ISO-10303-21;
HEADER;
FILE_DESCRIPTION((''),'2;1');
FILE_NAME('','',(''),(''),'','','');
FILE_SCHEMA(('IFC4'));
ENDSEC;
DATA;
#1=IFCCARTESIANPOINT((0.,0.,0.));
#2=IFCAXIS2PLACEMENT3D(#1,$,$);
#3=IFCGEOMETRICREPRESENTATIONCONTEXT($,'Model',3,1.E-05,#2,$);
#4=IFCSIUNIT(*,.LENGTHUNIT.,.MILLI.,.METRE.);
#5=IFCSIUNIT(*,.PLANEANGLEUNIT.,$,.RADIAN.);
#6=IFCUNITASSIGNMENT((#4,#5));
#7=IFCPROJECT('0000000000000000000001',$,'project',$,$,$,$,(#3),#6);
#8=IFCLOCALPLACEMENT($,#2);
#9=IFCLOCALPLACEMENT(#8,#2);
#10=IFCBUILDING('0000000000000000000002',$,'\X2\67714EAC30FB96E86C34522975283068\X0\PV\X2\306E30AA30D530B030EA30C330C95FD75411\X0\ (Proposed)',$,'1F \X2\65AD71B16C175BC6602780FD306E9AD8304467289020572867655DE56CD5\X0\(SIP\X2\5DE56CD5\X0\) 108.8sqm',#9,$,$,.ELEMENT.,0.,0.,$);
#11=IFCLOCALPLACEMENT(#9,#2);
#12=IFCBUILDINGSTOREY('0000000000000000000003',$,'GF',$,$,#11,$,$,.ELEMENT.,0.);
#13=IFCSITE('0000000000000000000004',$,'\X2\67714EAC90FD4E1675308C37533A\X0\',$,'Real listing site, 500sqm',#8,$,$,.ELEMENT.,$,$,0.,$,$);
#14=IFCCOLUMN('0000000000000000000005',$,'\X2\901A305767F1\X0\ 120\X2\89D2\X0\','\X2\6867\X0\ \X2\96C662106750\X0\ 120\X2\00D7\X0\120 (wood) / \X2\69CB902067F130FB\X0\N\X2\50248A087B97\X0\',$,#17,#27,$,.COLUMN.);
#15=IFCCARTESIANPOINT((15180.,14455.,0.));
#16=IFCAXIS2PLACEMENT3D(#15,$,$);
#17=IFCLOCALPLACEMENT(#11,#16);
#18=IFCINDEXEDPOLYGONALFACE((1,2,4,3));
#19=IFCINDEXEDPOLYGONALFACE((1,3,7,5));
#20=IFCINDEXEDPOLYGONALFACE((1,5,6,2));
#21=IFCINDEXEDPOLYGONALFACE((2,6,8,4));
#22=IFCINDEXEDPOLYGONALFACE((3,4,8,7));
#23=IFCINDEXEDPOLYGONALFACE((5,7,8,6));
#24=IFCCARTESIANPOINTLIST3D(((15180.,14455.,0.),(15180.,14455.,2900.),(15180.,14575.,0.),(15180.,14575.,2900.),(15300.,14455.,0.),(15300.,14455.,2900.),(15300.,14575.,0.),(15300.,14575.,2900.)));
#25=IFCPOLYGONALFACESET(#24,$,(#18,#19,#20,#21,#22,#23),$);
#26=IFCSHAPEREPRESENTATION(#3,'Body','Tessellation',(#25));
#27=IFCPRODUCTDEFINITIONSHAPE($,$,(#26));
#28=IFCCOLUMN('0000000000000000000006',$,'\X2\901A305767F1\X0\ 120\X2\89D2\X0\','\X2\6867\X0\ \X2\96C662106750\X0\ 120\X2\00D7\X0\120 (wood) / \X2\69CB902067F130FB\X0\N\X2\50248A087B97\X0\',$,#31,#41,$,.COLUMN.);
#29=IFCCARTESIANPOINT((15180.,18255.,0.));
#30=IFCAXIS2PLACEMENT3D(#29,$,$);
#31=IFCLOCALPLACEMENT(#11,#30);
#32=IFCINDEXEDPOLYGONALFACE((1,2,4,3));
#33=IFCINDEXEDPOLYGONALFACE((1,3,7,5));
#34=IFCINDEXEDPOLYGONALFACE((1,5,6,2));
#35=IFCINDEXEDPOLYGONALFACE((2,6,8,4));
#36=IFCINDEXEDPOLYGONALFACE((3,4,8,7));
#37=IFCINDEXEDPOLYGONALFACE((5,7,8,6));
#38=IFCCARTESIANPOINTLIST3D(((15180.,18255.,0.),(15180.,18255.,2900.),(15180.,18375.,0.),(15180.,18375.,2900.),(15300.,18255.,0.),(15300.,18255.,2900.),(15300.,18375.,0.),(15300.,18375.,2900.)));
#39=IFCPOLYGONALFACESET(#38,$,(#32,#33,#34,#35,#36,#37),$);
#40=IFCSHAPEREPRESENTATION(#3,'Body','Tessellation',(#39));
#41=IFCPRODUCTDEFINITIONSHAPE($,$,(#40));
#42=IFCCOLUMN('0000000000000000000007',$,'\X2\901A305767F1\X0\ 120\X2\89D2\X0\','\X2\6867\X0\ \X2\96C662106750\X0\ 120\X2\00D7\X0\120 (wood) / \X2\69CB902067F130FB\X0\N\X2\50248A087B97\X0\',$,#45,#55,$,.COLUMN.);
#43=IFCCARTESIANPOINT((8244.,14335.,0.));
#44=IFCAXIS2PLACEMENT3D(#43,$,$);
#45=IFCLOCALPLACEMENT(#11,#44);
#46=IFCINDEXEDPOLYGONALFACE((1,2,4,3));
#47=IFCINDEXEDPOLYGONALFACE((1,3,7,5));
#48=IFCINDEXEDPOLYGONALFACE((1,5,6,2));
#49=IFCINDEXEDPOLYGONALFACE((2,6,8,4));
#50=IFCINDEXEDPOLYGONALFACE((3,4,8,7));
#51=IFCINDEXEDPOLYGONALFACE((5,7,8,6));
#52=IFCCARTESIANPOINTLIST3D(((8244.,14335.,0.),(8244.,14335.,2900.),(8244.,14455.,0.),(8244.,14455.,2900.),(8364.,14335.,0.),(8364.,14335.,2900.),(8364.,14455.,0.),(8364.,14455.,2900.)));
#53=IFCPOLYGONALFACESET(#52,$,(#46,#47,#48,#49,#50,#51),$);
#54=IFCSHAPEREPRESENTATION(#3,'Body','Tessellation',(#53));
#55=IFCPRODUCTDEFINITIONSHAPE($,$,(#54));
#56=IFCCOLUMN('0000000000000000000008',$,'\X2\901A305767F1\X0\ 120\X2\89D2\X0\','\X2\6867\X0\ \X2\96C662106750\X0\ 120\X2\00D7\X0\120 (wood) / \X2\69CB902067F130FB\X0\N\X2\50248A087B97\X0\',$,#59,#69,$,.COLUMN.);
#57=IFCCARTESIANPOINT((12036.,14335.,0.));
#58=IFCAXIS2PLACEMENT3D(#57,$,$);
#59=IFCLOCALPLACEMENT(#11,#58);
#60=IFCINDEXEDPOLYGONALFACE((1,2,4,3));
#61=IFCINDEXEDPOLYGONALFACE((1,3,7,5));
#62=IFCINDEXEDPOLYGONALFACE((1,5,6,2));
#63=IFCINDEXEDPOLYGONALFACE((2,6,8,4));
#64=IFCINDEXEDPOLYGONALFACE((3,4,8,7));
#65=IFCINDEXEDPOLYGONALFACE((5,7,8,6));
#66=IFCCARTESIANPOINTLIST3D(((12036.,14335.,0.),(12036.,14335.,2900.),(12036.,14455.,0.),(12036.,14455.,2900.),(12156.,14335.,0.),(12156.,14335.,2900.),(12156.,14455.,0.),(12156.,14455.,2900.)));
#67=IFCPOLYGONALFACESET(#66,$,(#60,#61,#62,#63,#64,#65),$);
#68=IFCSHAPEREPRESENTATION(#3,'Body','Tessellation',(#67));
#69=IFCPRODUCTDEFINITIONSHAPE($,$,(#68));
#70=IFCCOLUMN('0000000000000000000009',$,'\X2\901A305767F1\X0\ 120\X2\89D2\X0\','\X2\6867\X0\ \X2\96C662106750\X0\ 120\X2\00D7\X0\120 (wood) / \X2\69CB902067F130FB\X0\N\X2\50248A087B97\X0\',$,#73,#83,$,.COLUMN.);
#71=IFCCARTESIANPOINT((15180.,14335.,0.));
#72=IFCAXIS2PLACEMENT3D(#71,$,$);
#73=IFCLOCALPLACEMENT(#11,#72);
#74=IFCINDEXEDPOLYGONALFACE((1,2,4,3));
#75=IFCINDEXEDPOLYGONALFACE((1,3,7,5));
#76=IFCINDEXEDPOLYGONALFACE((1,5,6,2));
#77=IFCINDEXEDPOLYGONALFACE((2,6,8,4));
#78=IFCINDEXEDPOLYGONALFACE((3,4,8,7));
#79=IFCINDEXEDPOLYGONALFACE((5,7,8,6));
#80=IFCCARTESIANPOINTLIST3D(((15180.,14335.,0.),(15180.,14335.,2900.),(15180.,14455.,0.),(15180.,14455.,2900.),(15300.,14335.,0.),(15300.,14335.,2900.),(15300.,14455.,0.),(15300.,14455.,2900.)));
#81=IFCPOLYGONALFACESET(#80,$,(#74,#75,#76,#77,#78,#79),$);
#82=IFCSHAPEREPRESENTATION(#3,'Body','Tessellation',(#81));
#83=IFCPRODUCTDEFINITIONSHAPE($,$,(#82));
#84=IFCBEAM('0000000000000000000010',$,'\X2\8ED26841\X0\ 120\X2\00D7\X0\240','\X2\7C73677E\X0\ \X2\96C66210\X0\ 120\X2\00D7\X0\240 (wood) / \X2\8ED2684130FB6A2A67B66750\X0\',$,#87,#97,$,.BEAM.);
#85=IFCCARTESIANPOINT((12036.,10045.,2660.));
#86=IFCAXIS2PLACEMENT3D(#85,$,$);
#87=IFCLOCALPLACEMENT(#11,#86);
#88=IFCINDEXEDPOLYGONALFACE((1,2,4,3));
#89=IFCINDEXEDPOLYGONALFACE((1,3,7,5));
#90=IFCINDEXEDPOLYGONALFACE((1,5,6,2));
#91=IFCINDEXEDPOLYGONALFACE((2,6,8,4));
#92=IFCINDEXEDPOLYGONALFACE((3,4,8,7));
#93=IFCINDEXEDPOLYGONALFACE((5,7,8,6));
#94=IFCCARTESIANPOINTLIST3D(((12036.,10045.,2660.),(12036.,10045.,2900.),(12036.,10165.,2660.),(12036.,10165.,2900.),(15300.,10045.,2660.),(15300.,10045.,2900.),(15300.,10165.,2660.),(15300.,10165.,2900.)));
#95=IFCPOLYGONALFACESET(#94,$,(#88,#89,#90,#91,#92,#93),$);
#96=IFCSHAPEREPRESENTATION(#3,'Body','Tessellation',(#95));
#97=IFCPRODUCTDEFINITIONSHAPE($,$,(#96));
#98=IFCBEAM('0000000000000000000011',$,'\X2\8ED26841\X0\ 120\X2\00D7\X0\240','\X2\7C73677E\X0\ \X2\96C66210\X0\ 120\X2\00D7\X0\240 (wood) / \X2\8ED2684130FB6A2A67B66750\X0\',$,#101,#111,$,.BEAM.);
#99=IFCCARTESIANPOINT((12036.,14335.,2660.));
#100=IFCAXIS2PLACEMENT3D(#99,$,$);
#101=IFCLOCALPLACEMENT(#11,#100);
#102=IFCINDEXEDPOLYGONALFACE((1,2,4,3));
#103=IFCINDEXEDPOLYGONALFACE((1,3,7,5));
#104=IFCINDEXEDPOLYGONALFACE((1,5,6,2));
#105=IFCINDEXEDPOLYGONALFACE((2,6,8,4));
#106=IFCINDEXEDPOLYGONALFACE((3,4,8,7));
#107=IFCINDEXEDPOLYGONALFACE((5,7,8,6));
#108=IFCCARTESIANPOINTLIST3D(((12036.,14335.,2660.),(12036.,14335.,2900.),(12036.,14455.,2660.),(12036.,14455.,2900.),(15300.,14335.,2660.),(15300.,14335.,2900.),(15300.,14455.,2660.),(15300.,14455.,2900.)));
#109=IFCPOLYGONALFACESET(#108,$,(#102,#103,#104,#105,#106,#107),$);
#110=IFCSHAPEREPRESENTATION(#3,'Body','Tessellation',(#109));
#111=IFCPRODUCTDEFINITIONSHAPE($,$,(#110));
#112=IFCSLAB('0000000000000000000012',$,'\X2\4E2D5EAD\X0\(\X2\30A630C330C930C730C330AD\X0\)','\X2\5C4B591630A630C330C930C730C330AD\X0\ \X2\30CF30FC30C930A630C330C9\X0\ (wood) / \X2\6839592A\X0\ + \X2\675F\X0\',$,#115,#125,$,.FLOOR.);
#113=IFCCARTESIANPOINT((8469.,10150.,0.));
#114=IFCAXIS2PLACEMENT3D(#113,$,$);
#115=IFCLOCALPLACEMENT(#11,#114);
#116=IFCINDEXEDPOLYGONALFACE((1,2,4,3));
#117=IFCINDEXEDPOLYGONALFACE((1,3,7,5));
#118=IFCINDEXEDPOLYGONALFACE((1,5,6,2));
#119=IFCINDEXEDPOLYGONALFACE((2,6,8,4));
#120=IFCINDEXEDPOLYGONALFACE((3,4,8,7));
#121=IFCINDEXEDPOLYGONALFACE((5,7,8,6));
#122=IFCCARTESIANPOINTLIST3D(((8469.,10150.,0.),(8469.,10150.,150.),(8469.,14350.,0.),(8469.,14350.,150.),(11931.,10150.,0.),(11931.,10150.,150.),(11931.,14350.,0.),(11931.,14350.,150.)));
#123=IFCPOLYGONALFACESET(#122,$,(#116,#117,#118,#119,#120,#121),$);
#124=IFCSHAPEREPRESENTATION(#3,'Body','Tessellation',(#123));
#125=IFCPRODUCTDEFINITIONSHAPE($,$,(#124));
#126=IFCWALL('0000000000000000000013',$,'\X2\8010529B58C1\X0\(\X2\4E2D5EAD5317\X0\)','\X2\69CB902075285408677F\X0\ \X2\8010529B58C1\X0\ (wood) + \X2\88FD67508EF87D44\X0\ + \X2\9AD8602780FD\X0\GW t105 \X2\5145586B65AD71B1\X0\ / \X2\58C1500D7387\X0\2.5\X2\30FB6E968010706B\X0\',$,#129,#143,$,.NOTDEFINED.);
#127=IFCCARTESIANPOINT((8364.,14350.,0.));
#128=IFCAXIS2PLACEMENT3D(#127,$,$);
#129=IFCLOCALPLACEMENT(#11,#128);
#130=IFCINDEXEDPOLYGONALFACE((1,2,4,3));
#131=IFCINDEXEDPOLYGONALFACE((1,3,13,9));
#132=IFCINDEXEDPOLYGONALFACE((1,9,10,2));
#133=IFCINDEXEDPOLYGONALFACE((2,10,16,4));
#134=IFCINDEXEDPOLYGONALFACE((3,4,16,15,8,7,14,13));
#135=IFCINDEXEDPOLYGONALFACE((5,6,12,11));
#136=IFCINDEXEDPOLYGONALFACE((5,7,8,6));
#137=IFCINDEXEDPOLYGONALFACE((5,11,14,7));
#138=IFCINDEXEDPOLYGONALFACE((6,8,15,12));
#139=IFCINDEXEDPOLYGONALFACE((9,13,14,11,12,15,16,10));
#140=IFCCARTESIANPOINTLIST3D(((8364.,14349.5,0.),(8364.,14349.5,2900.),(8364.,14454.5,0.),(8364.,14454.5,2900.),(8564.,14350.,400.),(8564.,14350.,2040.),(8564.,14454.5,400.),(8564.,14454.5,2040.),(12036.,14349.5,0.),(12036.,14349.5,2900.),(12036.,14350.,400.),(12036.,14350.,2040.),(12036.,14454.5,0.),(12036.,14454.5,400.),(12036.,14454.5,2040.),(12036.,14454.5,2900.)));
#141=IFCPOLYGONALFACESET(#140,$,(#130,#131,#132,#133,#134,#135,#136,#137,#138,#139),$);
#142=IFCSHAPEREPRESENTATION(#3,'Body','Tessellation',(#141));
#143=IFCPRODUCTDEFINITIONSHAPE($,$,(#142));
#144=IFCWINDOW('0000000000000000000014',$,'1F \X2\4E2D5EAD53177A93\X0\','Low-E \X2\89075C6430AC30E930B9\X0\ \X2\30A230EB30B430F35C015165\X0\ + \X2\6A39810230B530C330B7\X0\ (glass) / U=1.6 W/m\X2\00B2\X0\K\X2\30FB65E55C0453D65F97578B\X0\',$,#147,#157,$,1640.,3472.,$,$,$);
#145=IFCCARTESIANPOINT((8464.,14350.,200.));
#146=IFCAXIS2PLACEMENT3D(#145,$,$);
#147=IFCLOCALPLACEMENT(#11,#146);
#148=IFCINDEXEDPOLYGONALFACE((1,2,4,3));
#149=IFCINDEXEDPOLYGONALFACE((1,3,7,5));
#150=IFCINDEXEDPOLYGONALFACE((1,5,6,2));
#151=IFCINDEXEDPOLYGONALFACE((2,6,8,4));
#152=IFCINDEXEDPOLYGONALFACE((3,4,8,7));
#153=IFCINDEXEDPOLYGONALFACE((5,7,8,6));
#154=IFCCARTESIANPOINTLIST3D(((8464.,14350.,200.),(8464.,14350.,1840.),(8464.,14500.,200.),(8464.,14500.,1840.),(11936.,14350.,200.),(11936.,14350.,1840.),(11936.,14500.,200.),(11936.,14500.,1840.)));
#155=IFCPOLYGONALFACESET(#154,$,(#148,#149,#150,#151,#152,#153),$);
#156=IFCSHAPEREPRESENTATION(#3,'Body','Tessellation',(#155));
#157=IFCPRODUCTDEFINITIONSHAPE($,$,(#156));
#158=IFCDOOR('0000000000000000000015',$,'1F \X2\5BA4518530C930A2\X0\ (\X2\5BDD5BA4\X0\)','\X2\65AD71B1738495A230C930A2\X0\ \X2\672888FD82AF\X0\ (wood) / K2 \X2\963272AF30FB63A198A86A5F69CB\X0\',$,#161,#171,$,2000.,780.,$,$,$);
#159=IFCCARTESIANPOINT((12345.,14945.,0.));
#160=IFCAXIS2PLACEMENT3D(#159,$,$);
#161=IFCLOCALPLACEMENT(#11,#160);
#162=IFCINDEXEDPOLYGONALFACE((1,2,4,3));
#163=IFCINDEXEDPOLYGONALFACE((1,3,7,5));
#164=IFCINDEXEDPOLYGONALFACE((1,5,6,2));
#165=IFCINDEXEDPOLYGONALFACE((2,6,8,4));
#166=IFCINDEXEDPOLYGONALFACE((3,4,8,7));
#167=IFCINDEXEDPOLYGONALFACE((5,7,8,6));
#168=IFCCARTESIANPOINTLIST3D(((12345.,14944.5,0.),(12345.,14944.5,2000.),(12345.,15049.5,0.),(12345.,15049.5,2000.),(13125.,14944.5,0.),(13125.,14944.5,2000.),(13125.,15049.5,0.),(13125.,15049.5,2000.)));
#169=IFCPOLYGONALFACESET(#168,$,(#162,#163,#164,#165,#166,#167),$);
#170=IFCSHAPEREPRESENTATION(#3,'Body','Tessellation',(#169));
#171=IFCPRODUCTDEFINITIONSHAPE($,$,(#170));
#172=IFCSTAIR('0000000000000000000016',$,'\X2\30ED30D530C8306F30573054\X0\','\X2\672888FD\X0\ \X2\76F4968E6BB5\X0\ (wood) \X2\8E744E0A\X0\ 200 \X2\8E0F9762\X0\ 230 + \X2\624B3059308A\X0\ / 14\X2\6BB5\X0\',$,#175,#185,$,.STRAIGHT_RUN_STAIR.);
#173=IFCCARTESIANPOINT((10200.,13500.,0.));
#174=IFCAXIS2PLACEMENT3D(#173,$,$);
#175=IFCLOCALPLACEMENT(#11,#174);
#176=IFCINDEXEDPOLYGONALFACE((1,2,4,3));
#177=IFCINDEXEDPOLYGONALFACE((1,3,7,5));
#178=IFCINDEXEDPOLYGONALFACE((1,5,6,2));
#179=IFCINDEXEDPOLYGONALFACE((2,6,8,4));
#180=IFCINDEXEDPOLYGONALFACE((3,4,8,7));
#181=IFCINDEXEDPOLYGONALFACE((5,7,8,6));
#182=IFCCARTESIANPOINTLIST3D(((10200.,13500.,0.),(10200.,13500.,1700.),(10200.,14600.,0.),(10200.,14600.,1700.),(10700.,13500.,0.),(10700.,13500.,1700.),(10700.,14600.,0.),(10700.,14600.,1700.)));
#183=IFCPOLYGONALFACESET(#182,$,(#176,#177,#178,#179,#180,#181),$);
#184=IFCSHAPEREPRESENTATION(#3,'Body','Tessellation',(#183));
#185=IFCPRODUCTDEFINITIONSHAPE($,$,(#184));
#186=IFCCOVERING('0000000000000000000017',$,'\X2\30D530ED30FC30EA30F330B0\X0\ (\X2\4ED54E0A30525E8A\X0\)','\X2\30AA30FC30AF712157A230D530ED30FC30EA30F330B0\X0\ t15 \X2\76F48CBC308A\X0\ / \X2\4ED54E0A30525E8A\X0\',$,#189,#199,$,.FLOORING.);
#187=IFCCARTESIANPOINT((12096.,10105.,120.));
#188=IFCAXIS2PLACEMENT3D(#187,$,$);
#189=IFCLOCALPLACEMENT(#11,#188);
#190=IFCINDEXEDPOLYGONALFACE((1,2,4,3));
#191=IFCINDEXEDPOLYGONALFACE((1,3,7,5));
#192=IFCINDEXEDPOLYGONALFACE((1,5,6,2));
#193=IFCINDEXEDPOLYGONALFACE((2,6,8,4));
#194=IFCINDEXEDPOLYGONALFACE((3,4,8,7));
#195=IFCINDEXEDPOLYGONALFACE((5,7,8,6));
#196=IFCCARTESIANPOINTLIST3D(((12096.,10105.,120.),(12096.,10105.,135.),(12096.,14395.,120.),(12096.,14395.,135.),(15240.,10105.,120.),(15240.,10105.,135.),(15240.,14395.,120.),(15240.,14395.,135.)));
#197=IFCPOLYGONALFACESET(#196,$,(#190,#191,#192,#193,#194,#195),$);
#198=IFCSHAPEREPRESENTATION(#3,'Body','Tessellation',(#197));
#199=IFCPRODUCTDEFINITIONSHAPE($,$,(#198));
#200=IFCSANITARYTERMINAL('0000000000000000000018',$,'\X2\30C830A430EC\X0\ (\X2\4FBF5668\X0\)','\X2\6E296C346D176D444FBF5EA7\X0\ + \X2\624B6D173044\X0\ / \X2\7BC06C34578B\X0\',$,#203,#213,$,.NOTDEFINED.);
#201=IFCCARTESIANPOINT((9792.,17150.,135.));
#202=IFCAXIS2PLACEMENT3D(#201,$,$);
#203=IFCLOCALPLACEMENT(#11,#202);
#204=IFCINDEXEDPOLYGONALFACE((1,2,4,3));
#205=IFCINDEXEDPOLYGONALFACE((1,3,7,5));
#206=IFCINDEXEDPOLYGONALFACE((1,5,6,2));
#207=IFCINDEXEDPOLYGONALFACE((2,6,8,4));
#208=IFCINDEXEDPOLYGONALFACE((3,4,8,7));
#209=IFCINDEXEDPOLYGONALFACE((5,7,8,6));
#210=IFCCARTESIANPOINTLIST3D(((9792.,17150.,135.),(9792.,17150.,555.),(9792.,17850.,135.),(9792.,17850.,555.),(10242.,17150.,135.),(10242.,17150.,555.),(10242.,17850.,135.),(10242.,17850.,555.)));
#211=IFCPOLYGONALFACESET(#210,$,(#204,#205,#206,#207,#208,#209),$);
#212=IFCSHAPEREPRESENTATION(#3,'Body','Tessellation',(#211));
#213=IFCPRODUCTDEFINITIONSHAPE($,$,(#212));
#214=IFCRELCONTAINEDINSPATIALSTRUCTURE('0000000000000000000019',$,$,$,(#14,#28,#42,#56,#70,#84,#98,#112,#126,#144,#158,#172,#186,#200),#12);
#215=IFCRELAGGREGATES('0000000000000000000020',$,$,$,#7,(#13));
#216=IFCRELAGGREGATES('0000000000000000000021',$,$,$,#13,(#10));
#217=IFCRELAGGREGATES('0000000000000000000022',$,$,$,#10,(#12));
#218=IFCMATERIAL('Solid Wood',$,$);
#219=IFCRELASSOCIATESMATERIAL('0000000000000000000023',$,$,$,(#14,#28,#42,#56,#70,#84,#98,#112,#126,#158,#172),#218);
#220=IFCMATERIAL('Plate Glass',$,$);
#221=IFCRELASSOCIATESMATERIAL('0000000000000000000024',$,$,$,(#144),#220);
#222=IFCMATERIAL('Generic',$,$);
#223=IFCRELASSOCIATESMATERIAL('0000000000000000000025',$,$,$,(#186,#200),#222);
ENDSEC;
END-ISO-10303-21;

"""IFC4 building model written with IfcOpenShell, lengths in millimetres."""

from ifc_helpers import new_model, si_unit, frame, frame_2d, origin, place, context, project, spatial, rectangle, extrude, material, element, fill, save


model = new_model("IFC4")

# Units and contexts
model_context = context("Model", 3, precision=1e-05, world=origin())
ifc_project = project(units=[si_unit("LENGTHUNIT", "METRE", prefix="MILLI"), si_unit("PLANEANGLEUNIT", "RADIAN")], contexts=[model_context])

# Site, building, storey
site_placement = place(None, origin())
site = spatial("IfcSite", under=ifc_project, at=site_placement, Name="東京都世田谷区", ObjectType="Real listing site, 500sqm", CompositionType="ELEMENT", RefElevation=0.0)
building_placement = place(site_placement, origin())
building = spatial("IfcBuilding", under=site, at=building_placement, Name="東京・雨水利用とPVのオフグリッド志向 (Proposed)", ObjectType="1F 断熱気密性能の高い木造在来工法(SIP工法) 108.8sqm", CompositionType="ELEMENT", ElevationOfRefHeight=0.0, ElevationOfTerrain=0.0)
storey_placement = place(building_placement, origin())
storey = spatial("IfcBuildingStorey", under=building, at=storey_placement, Name="GF", CompositionType="ELEMENT", Elevation=0.0)

# Columns
ifc_material_1 = material(Name="Solid Wood")
column_1_placement = place(storey_placement, frame((15180.0, 14455.0, 0.0)))
element("IfcColumn", 1, at=column_1_placement, inside=storey, material=ifc_material_1, Name="通し柱 120角", Description="桧 集成材 120×120 (wood) / 構造柱・N値計算", PredefinedType="COLUMN", context=model_context, shape_type="SweptSolid", body=[
    extrude(rectangle(XDim=120.0, YDim=120.0, at=frame_2d((60.0, 60.0))), frame((15180.0, 14455.0, 0.0)), (0.0, 0.0, 1.0), 2900.0),
])
column_2_placement = place(storey_placement, frame((15180.0, 18255.0, 0.0)))
element("IfcColumn", 2, at=column_2_placement, inside=storey, material=ifc_material_1, Name="通し柱 120角", Description="桧 集成材 120×120 (wood) / 構造柱・N値計算", PredefinedType="COLUMN", context=model_context, shape_type="SweptSolid", body=[
    extrude(rectangle(XDim=120.0, YDim=120.0, at=frame_2d((60.0, 60.0))), frame((15180.0, 18255.0, 0.0)), (0.0, 0.0, 1.0), 2900.0),
])
column_3_placement = place(storey_placement, frame((8244.0, 14335.0, 0.0)))
element("IfcColumn", 3, at=column_3_placement, inside=storey, material=ifc_material_1, Name="通し柱 120角", Description="桧 集成材 120×120 (wood) / 構造柱・N値計算", PredefinedType="COLUMN", context=model_context, shape_type="SweptSolid", body=[
    extrude(rectangle(XDim=120.0, YDim=120.0, at=frame_2d((60.0, 60.0))), frame((8244.0, 14335.0, 0.0)), (0.0, 0.0, 1.0), 2900.0),
])
column_4_placement = place(storey_placement, frame((12036.0, 14335.0, 0.0)))
element("IfcColumn", 4, at=column_4_placement, inside=storey, material=ifc_material_1, Name="通し柱 120角", Description="桧 集成材 120×120 (wood) / 構造柱・N値計算", PredefinedType="COLUMN", context=model_context, shape_type="SweptSolid", body=[
    extrude(rectangle(XDim=120.0, YDim=120.0, at=frame_2d((60.0, 60.0))), frame((12036.0, 14335.0, 0.0)), (0.0, 0.0, 1.0), 2900.0),
])
column_5_placement = place(storey_placement, frame((15180.0, 14335.0, 0.0)))
element("IfcColumn", 5, at=column_5_placement, inside=storey, material=ifc_material_1, Name="通し柱 120角", Description="桧 集成材 120×120 (wood) / 構造柱・N値計算", PredefinedType="COLUMN", context=model_context, shape_type="SweptSolid", body=[
    extrude(rectangle(XDim=120.0, YDim=120.0, at=frame_2d((60.0, 60.0))), frame((15180.0, 14335.0, 0.0)), (0.0, 0.0, 1.0), 2900.0),
])

# Beams
beam_1_placement = place(storey_placement, frame((12036.0, 10045.0, 2660.0)))
element("IfcBeam", 6, at=beam_1_placement, inside=storey, material=ifc_material_1, Name="軒桁 120×240", Description="米松 集成 120×240 (wood) / 軒桁・横架材", PredefinedType="BEAM", context=model_context, shape_type="SweptSolid", body=[
    extrude(rectangle(XDim=3264.0, YDim=120.0, at=frame_2d((1632.0, 60.0))), frame((12036.0, 10045.0, 2660.0)), (0.0, 0.0, 1.0), 240.0),
])
beam_2_placement = place(storey_placement, frame((12036.0, 14335.0, 2660.0)))
element("IfcBeam", 7, at=beam_2_placement, inside=storey, material=ifc_material_1, Name="軒桁 120×240", Description="米松 集成 120×240 (wood) / 軒桁・横架材", PredefinedType="BEAM", context=model_context, shape_type="SweptSolid", body=[
    extrude(rectangle(XDim=3264.0, YDim=120.0, at=frame_2d((1632.0, 60.0))), frame((12036.0, 14335.0, 2660.0)), (0.0, 0.0, 1.0), 240.0),
])

# Slab
slab_placement = place(storey_placement, frame((8469.0, 10150.0, 0.0)))
element("IfcSlab", 8, at=slab_placement, inside=storey, material=ifc_material_1, Name="中庭(ウッドデッキ)", Description="屋外ウッドデッキ ハードウッド (wood) / 根太 + 束", PredefinedType="FLOOR", context=model_context, shape_type="SweptSolid", body=[
    extrude(rectangle(XDim=3462.0, YDim=4200.0, at=frame_2d((1731.0, 2100.0))), frame((8469.0, 10150.0, 0.0)), (0.0, 0.0, 1.0), 150.0),
])

# Wall, opening, window
wall_1_placement = place(storey_placement, frame((8364.0, 14350.0, 0.0)))
wall_1 = element("IfcWall", 9, at=wall_1_placement, inside=storey, material=ifc_material_1, Name="耐力壁(中庭北)", Description="構造用合板 耐力壁 (wood) + 製材軸組 + 高性能GW t105 充填断熱 / 壁倍率2.5・準耐火", PredefinedType="NOTDEFINED", context=model_context, shape_type="SweptSolid", body=[
    extrude(rectangle(XDim=3672.0, YDim=105.0, at=frame_2d((1836.0, 52.0))), frame((8364.0, 14350.0, 0.0)), (0.0, 0.0, 1.0), 2900.0),
])
opening_placement = place(storey_placement, frame((8464.0, 14350.0, 200.0)))
opening = element("IfcOpeningElement", 10, at=opening_placement, cuts=wall_1, PredefinedType="NOTDEFINED", context=model_context, shape_type="SweptSolid", body=[
    extrude(rectangle(XDim=3472.0, YDim=150.0, at=frame_2d((1736.0, 75.0))), frame((8464.0, 14350.0, 200.0)), (0.0, 0.0, 1.0), 1640.0),
])
ifc_material_2 = material(Name="Plate Glass")
window_placement = place(storey_placement, frame((8464.0, 14350.0, 200.0)))
window = element("IfcWindow", 11, at=window_placement, inside=storey, material=ifc_material_2, Name="1F 中庭北窓", Description="Low-E 複層ガラス アルゴン封入 + 樹脂サッシ (glass) / U=1.6 W/m²K・日射取得型", OverallHeight=1640.0, OverallWidth=3472.0, context=model_context, shape_type="SweptSolid", body=[
    extrude(rectangle(XDim=3472.0, YDim=150.0, at=frame_2d((1736.0, 75.0))), frame((8464.0, 14350.0, 200.0)), (0.0, 0.0, 1.0), 1640.0),
])
fill(opening, window)

# Door
door_placement = place(storey_placement, frame((12345.0, 14945.0, 0.0)))
element("IfcDoor", 12, at=door_placement, inside=storey, material=ifc_material_1, Name="1F 室内ドア (寝室)", Description="断熱玄関ドア 木製芯 (wood) / K2 防犯・採風機構", OverallHeight=2000.0, OverallWidth=780.0, context=model_context, shape_type="SweptSolid", body=[
    extrude(rectangle(XDim=780.0, YDim=105.0, at=frame_2d((390.0, 52.0))), frame((12345.0, 14945.0, 0.0)), (0.0, 0.0, 1.0), 2000.0),
])

# Stair
stair_placement = place(storey_placement, frame((10200.0, 13500.0, 0.0)))
element("IfcStair", 13, at=stair_placement, inside=storey, material=ifc_material_1, Name="ロフトはしご", Description="木製 直階段 (wood) 蹴上 200 踏面 230 + 手すり / 14段", PredefinedType="STRAIGHT_RUN_STAIR", context=model_context, shape_type="SweptSolid", body=[
    extrude(rectangle(XDim=500.0, YDim=1100.0, at=frame_2d((250.0, 550.0))), frame((10200.0, 13500.0, 0.0)), (0.0, 0.0, 1.0), 1700.0),
])

# Covering
ifc_material_3 = material(Name="Generic")
covering_placement = place(storey_placement, frame((12096.0, 10105.0, 120.0)))
element("IfcCovering", 14, at=covering_placement, inside=storey, material=ifc_material_3, Name="フローリング (仕上げ床)", Description="オーク無垢フローリング t15 直貼り / 仕上げ床", PredefinedType="FLOORING", context=model_context, shape_type="SweptSolid", body=[
    extrude(rectangle(XDim=3144.0, YDim=4290.0, at=frame_2d((1572.0, 2145.0))), frame((12096.0, 10105.0, 120.0)), (0.0, 0.0, 1.0), 15.0),
])

# Sanitary terminal
sanitary_terminal_placement = place(storey_placement, frame((9792.0, 17150.0, 135.0)))
element("IfcSanitaryTerminal", 15, at=sanitary_terminal_placement, inside=storey, material=ifc_material_3, Name="トイレ (便器)", Description="温水洗浄便座 + 手洗い / 節水型", PredefinedType="NOTDEFINED", context=model_context, shape_type="SweptSolid", body=[
    extrude(rectangle(XDim=450.0, YDim=700.0, at=frame_2d((225.0, 350.0))), frame((9792.0, 17150.0, 135.0)), (0.0, 0.0, 1.0), 420.0),
])

save(model, "model.ifc")
